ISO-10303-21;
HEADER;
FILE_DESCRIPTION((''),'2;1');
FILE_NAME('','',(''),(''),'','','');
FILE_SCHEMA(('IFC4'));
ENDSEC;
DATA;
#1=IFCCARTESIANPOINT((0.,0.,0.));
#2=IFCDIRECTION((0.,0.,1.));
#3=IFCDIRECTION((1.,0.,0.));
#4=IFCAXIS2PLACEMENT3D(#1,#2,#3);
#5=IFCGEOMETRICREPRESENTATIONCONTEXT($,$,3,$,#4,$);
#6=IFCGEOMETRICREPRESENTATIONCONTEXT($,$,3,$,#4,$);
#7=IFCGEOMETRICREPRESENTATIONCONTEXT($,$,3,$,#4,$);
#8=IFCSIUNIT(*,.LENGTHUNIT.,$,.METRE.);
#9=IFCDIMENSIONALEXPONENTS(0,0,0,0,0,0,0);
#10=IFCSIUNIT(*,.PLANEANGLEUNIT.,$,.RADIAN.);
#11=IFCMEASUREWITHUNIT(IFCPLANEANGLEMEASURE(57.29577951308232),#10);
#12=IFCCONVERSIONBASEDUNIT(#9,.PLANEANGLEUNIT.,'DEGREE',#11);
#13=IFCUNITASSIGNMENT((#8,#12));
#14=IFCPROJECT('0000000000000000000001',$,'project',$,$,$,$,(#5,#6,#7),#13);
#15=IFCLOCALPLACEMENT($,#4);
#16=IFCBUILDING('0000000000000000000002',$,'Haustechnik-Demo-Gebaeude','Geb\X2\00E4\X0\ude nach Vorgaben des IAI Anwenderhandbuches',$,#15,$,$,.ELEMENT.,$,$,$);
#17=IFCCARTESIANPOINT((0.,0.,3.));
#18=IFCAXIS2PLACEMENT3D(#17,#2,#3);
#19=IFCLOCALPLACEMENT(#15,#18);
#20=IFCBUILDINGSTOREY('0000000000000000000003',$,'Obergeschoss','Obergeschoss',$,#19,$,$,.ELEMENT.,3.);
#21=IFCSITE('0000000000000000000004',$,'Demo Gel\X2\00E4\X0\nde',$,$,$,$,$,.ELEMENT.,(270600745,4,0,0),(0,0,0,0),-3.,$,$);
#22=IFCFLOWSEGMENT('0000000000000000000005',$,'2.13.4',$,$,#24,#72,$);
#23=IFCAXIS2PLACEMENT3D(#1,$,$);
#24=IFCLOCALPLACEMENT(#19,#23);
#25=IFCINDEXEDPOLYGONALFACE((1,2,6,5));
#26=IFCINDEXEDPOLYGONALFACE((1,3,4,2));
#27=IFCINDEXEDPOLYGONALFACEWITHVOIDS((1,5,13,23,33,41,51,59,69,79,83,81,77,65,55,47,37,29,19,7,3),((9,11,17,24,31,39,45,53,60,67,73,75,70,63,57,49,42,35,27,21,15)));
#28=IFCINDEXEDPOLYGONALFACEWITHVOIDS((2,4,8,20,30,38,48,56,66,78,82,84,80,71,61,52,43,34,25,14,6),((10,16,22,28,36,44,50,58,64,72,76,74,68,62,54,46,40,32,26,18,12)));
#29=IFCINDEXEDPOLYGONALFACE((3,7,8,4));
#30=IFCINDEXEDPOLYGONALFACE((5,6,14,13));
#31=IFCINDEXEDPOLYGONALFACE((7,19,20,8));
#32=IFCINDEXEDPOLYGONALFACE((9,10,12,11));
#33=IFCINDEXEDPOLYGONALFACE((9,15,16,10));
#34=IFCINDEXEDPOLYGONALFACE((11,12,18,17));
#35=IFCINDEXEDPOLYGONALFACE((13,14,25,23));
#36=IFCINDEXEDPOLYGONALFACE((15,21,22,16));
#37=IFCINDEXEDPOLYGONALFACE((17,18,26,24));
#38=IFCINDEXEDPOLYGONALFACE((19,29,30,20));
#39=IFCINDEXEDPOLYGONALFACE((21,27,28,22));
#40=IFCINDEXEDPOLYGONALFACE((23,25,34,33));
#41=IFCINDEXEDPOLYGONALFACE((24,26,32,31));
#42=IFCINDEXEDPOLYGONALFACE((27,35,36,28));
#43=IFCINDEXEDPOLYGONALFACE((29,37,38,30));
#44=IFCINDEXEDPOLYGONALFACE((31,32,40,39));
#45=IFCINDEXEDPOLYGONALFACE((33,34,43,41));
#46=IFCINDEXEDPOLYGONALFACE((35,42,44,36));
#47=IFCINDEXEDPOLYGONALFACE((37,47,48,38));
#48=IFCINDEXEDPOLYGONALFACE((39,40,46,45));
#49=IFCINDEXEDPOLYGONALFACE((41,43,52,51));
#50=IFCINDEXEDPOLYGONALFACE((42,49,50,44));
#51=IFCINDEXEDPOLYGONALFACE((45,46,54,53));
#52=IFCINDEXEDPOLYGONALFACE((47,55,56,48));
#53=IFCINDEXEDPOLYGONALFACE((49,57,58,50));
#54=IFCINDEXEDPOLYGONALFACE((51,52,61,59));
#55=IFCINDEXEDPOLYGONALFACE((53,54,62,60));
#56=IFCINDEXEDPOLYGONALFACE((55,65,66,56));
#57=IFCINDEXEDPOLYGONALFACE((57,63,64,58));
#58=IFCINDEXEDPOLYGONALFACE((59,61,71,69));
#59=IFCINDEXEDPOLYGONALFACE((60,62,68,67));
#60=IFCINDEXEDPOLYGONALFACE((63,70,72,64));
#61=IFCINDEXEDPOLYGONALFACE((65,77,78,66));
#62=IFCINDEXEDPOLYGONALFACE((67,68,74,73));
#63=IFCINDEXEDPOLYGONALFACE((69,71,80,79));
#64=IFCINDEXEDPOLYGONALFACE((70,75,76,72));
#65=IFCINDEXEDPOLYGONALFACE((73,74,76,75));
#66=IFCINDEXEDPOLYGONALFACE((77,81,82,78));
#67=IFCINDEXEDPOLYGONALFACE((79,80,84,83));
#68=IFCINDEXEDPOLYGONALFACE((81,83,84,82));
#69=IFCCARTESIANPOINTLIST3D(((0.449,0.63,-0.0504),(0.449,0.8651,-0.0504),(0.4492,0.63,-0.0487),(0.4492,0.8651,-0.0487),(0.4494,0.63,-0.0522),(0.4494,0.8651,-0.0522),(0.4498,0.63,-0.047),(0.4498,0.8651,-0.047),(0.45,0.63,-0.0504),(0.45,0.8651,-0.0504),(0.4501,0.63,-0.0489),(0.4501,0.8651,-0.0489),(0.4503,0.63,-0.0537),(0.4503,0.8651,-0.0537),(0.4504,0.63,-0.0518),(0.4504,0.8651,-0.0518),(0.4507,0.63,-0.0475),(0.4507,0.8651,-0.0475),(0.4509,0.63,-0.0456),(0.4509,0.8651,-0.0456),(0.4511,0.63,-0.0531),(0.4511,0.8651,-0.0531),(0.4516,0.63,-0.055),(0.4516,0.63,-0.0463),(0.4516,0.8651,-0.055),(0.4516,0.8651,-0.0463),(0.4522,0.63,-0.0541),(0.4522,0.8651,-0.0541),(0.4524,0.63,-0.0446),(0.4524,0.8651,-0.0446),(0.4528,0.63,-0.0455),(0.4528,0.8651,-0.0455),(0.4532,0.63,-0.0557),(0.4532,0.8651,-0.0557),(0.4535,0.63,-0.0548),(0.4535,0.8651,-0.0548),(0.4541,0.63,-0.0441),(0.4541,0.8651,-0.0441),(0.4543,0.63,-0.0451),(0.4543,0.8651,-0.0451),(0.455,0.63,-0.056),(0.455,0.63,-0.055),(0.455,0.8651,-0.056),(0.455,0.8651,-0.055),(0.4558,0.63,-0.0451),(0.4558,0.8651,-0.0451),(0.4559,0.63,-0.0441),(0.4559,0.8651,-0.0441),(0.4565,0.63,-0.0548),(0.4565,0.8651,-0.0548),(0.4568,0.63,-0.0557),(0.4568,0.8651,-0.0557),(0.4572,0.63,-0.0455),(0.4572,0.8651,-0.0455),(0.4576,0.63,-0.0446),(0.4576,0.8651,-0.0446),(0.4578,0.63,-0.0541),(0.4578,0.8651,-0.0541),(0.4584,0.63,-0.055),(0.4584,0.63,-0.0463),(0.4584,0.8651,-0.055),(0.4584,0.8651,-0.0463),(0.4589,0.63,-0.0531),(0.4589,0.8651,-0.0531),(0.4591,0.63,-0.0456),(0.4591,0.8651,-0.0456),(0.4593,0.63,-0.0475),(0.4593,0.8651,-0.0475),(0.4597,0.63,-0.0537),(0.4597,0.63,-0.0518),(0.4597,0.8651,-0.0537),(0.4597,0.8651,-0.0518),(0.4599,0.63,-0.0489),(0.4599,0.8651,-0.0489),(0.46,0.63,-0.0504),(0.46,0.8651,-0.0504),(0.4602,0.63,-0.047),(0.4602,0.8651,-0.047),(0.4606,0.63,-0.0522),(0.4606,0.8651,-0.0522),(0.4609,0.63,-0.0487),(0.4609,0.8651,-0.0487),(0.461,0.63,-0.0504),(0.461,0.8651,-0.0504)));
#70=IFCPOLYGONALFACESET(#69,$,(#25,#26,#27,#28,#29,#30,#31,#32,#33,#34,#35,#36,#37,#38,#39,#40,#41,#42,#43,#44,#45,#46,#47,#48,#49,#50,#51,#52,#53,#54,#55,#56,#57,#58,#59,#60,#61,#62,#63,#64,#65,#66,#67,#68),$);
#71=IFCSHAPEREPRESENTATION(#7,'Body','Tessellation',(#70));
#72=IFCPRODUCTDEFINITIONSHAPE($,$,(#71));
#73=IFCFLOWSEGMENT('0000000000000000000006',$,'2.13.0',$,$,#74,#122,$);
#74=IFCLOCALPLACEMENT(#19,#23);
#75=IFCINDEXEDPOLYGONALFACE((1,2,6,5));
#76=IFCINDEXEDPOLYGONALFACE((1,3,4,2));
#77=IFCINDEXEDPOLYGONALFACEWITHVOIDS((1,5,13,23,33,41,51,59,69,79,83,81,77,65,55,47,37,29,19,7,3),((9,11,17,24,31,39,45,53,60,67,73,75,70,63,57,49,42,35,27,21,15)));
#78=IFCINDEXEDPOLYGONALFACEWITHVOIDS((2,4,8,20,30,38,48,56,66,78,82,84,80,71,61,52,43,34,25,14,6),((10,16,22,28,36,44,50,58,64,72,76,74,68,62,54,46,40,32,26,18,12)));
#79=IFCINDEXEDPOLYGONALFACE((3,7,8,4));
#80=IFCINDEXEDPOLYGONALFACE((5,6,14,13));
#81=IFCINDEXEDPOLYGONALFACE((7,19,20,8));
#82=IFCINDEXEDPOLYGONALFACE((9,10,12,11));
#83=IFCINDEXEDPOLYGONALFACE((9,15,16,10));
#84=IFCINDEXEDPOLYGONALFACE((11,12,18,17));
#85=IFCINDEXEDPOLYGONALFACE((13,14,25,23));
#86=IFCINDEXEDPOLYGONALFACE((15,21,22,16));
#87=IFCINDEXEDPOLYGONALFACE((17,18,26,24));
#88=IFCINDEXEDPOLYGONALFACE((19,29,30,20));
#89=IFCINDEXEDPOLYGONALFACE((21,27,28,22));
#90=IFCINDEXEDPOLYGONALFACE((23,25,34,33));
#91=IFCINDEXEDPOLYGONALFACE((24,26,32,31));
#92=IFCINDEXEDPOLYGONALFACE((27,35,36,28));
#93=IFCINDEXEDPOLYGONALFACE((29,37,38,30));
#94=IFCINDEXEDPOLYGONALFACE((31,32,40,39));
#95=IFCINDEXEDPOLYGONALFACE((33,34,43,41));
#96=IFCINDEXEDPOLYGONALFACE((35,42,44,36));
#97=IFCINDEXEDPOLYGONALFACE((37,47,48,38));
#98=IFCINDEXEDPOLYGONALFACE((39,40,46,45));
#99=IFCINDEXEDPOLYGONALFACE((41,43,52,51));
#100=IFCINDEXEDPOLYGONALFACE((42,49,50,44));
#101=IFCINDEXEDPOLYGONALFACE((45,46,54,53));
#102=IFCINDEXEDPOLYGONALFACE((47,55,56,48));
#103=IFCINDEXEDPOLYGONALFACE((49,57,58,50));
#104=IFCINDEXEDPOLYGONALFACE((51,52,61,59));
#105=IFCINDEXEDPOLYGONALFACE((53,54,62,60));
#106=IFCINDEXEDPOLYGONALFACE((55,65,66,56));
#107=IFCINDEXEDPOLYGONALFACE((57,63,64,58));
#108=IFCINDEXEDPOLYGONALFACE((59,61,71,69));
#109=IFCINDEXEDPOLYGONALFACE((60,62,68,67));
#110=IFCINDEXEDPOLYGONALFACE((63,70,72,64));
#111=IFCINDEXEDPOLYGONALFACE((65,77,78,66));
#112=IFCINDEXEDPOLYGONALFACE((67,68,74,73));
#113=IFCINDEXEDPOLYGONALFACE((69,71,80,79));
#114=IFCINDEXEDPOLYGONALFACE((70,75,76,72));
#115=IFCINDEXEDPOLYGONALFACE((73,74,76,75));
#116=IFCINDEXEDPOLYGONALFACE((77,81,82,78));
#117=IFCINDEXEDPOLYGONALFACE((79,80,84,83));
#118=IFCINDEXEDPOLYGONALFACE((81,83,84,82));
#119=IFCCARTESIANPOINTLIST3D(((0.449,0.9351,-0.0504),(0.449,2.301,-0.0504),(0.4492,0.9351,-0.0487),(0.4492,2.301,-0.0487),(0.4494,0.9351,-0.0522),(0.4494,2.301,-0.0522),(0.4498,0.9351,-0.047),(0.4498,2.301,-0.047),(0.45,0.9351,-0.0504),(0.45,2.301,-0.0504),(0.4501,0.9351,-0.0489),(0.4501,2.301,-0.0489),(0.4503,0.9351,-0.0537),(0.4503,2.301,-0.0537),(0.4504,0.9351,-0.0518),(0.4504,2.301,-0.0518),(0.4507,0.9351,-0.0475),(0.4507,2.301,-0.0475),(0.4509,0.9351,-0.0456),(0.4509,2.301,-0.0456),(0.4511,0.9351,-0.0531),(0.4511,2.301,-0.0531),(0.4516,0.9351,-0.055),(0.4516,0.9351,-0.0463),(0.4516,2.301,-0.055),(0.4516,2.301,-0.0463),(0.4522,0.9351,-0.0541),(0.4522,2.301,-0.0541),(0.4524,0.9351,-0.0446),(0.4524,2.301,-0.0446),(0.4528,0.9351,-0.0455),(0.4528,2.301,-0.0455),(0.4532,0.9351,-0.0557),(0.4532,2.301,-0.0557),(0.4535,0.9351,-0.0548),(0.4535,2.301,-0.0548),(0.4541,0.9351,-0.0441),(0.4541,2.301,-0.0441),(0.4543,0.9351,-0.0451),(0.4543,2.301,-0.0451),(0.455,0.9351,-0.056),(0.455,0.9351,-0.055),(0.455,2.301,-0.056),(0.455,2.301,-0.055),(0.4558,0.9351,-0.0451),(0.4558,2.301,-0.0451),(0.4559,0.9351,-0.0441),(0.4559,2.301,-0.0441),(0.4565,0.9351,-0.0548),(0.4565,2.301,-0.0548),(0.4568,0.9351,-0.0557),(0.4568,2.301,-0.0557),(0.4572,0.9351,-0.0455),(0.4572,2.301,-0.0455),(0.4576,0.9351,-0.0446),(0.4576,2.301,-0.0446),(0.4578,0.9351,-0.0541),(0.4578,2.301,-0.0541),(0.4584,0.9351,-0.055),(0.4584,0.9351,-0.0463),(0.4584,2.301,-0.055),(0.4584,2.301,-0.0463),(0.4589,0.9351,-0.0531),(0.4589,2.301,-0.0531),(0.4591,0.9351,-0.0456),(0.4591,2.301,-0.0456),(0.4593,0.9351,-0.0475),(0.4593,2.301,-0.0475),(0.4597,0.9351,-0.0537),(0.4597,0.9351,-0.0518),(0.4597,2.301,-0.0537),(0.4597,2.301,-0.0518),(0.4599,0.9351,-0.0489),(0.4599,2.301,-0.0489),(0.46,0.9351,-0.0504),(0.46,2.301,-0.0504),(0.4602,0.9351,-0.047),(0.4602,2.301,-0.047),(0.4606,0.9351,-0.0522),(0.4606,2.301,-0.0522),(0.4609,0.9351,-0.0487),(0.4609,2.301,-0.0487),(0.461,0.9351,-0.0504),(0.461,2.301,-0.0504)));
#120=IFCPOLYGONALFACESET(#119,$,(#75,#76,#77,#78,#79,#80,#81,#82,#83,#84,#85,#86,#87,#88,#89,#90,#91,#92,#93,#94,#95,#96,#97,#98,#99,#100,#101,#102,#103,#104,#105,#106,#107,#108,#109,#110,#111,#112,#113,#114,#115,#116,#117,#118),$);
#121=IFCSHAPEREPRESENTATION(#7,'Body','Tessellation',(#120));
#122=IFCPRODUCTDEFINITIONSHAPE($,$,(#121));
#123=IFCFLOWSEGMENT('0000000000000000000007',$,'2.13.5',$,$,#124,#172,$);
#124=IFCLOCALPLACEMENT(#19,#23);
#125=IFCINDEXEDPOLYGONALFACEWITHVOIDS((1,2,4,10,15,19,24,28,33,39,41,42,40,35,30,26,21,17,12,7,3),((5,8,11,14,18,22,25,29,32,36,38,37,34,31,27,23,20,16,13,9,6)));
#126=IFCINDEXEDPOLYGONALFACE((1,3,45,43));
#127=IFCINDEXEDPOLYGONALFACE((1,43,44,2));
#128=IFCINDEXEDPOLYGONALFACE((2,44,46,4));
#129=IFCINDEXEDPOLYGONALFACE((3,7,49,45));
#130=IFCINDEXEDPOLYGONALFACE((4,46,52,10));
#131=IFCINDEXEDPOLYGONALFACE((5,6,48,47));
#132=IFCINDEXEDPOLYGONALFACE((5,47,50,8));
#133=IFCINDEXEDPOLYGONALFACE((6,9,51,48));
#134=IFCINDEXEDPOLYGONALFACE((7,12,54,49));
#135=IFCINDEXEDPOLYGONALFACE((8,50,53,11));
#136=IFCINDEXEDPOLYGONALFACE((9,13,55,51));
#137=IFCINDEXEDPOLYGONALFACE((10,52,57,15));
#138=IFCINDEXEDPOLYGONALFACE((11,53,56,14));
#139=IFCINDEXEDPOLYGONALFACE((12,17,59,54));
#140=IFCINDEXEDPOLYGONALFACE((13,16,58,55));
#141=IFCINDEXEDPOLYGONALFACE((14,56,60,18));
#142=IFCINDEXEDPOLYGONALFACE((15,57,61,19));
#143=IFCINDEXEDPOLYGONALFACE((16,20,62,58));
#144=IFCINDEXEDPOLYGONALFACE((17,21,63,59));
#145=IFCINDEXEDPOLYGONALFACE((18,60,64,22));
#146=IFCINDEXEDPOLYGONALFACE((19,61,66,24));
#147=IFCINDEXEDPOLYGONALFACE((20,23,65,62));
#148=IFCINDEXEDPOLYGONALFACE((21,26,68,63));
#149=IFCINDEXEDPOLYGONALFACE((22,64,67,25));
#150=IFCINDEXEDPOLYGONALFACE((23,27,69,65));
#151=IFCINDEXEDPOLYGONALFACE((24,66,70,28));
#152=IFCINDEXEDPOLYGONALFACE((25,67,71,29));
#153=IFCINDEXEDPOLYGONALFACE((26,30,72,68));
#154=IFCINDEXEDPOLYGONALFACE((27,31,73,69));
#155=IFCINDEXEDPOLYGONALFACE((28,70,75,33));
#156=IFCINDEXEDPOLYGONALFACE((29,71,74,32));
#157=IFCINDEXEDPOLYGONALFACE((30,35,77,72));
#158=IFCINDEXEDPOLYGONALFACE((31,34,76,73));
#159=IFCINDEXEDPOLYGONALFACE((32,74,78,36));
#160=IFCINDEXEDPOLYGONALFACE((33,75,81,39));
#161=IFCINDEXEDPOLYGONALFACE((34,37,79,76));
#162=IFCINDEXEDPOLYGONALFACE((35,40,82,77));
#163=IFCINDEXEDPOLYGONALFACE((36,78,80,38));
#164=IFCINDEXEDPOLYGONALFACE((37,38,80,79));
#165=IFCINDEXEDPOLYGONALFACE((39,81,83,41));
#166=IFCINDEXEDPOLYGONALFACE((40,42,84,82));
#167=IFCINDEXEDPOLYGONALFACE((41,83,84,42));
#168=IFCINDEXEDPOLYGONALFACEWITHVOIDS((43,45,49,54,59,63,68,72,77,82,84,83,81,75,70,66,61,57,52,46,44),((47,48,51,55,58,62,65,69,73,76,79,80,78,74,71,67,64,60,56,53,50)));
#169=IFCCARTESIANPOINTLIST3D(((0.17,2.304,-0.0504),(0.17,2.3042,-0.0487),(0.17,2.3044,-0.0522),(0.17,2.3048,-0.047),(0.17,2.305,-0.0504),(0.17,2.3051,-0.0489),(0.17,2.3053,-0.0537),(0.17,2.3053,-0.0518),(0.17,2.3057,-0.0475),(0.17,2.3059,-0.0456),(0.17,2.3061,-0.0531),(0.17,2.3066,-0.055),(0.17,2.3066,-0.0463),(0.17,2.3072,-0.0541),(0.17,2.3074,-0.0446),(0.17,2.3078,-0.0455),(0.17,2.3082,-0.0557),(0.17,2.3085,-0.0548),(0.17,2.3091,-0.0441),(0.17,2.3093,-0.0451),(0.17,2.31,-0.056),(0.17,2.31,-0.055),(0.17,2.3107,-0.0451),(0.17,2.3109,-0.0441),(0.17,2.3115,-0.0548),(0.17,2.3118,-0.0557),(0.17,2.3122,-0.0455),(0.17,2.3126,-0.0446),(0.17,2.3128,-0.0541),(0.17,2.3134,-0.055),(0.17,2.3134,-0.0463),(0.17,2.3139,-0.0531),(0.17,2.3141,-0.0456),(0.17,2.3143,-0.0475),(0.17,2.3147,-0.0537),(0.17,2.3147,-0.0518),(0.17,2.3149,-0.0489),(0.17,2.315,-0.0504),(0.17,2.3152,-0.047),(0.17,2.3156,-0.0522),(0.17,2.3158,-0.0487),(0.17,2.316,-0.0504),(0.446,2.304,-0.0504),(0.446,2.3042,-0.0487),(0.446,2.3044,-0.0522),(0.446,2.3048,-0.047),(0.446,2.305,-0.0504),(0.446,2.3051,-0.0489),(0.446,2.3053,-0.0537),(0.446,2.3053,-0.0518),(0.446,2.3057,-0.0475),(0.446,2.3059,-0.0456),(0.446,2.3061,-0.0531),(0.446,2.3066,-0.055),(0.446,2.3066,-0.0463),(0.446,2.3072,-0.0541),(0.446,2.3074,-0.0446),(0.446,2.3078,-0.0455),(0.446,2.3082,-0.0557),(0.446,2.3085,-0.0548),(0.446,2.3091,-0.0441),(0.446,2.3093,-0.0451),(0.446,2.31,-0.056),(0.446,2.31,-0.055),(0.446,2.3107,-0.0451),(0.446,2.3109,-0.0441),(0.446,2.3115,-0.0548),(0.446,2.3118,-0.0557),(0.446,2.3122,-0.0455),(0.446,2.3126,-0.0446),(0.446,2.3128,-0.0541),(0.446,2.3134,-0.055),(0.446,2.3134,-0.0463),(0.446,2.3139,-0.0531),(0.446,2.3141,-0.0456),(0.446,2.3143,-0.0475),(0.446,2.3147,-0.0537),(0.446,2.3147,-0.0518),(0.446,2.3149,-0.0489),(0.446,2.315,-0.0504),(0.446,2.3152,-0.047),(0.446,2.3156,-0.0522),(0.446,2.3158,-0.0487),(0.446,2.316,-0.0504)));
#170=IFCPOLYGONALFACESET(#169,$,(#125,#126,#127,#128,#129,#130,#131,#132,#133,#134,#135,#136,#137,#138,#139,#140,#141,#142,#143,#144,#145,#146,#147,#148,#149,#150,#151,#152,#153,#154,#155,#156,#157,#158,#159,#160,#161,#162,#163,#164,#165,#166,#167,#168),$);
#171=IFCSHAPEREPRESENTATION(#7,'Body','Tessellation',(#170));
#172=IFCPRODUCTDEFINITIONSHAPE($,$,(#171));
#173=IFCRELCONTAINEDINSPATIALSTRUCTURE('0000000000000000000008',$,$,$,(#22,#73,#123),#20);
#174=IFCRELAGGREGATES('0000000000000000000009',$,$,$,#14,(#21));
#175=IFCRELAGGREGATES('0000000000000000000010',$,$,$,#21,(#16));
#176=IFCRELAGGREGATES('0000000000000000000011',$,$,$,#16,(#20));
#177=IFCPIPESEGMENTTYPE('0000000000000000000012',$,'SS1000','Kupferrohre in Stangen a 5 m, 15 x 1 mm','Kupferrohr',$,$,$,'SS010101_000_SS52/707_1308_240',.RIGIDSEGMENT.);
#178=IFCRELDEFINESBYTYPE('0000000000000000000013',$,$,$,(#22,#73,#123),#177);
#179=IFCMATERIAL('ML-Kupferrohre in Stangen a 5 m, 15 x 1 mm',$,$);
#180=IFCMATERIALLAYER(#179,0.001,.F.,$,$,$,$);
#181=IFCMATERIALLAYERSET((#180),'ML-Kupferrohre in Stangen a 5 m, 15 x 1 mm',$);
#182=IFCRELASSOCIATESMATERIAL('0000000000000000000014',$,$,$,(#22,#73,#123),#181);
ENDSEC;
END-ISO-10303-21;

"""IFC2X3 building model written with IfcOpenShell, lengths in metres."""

from ifc_helpers import new_model, entity, si_unit, converted_unit, frame, origin_with_axes, origin_2d_with_axis, place, context, project, spatial, hollow_circle, extrude, material, layer, layer_set, layer_usage, type_object, element, save


model = new_model("IFC2X3")

# Units and contexts
context_of_model_1 = context(None, 3, world=origin_with_axes())
context_of_model_2 = context(None, 3, world=origin_with_axes())
context_of_model_3 = context(None, 3, world=origin_with_axes())
ifc_project = project(units=[si_unit("LENGTHUNIT", "METRE"), converted_unit("PLANEANGLEUNIT", "DEGREE", entity("IfcPlaneAngleMeasure", 57.29577951308232), si_unit("PLANEANGLEUNIT", "RADIAN"), dimensions=[0, 0, 0, 0, 0, 0, 0])], contexts=[context_of_model_1, context_of_model_2, context_of_model_3])

# Site, building, storey
site = spatial("IfcSite", under=ifc_project, Name="Demo Gelände", CompositionType="ELEMENT", RefLatitude=(270600745, 4, 0, 0), RefLongitude=(0, 0, 0, 0), RefElevation=-3.0)
building_placement = place(None, origin_with_axes())
building = spatial("IfcBuilding", under=site, at=building_placement, Name="Haustechnik-Demo-Gebaeude", Description="Gebäude nach Vorgaben des IAI Anwenderhandbuches", CompositionType="ELEMENT")
storey_placement = place(building_placement, frame((0.0, 0.0, 3.0), z_axis=(0.0, 0.0, 1.0), x_axis=(1.0, 0.0, 0.0)))
storey = spatial("IfcBuildingStorey", under=building, at=storey_placement, Name="Obergeschoss", Description="Obergeschoss", CompositionType="ELEMENT", Elevation=3.0)

# Flow segments
ifc_material = material(Name="ML-Kupferrohre in Stangen a 5 m, 15 x 1 mm")
ifc_layer = layer(ifc_material, 0.001, ventilated=False)
ifc_layer_set = layer_set([ifc_layer], Name="ML-Kupferrohre in Stangen a 5 m, 15 x 1 mm")
ifc_layer_usage = layer_usage(ifc_layer_set, "AXIS2", "POSITIVE", 0.0)
pipe_segment_type_1 = type_object("IfcPipeSegmentType", Name="SS1000", Description="Kupferrohre in Stangen a 5 m, 15 x 1 mm", ApplicableOccurrence="Kupferrohr", ElementType="SS010101_000_SS52/707_1308_240", PredefinedType="RIGIDSEGMENT")
flow_segment_1_placement = place(storey_placement, frame((0.455, 0.63, -0.05), z_axis=(0.0, 1.0, 0.0), x_axis=(0.0, 0.0, -1.0)))
element("IfcFlowSegment", 1, at=flow_segment_1_placement, inside=storey, type_object=pipe_segment_type_1, material=ifc_layer_usage, Name="2.13.4", context=context_of_model_3, shape_type="SweptSolid", body=[
    extrude(hollow_circle(Radius=0.006, WallThickness=0.001, at=origin_2d_with_axis()), origin_with_axes(), (0.0, 0.0, 1.0), 0.2351),
])
flow_segment_2_placement = place(storey_placement, frame((0.455, 0.9351, -0.05), z_axis=(0.0, 1.0, 0.0), x_axis=(0.0, 0.0, -1.0)))
element("IfcFlowSegment", 2, at=flow_segment_2_placement, inside=storey, type_object=pipe_segment_type_1, material=ifc_layer_usage, Name="2.13.0", context=context_of_model_3, shape_type="SweptSolid", body=[
    extrude(hollow_circle(Radius=0.006, WallThickness=0.001, at=origin_2d_with_axis()), origin_with_axes(), (0.0, 0.0, 1.0), 1.3659),
])
flow_segment_3_placement = place(storey_placement, frame((0.446, 2.31, -0.05), z_axis=(-1.0, 0.0, 0.0), x_axis=(0.0, 0.0, -1.0)))
element("IfcFlowSegment", 3, at=flow_segment_3_placement, inside=storey, type_object=pipe_segment_type_1, material=ifc_layer_usage, Name="2.13.5", context=context_of_model_3, shape_type="SweptSolid", body=[
    extrude(hollow_circle(Radius=0.006, WallThickness=0.001, at=origin_2d_with_axis()), origin_with_axes(), (0.0, 0.0, 1.0), 0.276),
])

save(model, "model.ifc")
